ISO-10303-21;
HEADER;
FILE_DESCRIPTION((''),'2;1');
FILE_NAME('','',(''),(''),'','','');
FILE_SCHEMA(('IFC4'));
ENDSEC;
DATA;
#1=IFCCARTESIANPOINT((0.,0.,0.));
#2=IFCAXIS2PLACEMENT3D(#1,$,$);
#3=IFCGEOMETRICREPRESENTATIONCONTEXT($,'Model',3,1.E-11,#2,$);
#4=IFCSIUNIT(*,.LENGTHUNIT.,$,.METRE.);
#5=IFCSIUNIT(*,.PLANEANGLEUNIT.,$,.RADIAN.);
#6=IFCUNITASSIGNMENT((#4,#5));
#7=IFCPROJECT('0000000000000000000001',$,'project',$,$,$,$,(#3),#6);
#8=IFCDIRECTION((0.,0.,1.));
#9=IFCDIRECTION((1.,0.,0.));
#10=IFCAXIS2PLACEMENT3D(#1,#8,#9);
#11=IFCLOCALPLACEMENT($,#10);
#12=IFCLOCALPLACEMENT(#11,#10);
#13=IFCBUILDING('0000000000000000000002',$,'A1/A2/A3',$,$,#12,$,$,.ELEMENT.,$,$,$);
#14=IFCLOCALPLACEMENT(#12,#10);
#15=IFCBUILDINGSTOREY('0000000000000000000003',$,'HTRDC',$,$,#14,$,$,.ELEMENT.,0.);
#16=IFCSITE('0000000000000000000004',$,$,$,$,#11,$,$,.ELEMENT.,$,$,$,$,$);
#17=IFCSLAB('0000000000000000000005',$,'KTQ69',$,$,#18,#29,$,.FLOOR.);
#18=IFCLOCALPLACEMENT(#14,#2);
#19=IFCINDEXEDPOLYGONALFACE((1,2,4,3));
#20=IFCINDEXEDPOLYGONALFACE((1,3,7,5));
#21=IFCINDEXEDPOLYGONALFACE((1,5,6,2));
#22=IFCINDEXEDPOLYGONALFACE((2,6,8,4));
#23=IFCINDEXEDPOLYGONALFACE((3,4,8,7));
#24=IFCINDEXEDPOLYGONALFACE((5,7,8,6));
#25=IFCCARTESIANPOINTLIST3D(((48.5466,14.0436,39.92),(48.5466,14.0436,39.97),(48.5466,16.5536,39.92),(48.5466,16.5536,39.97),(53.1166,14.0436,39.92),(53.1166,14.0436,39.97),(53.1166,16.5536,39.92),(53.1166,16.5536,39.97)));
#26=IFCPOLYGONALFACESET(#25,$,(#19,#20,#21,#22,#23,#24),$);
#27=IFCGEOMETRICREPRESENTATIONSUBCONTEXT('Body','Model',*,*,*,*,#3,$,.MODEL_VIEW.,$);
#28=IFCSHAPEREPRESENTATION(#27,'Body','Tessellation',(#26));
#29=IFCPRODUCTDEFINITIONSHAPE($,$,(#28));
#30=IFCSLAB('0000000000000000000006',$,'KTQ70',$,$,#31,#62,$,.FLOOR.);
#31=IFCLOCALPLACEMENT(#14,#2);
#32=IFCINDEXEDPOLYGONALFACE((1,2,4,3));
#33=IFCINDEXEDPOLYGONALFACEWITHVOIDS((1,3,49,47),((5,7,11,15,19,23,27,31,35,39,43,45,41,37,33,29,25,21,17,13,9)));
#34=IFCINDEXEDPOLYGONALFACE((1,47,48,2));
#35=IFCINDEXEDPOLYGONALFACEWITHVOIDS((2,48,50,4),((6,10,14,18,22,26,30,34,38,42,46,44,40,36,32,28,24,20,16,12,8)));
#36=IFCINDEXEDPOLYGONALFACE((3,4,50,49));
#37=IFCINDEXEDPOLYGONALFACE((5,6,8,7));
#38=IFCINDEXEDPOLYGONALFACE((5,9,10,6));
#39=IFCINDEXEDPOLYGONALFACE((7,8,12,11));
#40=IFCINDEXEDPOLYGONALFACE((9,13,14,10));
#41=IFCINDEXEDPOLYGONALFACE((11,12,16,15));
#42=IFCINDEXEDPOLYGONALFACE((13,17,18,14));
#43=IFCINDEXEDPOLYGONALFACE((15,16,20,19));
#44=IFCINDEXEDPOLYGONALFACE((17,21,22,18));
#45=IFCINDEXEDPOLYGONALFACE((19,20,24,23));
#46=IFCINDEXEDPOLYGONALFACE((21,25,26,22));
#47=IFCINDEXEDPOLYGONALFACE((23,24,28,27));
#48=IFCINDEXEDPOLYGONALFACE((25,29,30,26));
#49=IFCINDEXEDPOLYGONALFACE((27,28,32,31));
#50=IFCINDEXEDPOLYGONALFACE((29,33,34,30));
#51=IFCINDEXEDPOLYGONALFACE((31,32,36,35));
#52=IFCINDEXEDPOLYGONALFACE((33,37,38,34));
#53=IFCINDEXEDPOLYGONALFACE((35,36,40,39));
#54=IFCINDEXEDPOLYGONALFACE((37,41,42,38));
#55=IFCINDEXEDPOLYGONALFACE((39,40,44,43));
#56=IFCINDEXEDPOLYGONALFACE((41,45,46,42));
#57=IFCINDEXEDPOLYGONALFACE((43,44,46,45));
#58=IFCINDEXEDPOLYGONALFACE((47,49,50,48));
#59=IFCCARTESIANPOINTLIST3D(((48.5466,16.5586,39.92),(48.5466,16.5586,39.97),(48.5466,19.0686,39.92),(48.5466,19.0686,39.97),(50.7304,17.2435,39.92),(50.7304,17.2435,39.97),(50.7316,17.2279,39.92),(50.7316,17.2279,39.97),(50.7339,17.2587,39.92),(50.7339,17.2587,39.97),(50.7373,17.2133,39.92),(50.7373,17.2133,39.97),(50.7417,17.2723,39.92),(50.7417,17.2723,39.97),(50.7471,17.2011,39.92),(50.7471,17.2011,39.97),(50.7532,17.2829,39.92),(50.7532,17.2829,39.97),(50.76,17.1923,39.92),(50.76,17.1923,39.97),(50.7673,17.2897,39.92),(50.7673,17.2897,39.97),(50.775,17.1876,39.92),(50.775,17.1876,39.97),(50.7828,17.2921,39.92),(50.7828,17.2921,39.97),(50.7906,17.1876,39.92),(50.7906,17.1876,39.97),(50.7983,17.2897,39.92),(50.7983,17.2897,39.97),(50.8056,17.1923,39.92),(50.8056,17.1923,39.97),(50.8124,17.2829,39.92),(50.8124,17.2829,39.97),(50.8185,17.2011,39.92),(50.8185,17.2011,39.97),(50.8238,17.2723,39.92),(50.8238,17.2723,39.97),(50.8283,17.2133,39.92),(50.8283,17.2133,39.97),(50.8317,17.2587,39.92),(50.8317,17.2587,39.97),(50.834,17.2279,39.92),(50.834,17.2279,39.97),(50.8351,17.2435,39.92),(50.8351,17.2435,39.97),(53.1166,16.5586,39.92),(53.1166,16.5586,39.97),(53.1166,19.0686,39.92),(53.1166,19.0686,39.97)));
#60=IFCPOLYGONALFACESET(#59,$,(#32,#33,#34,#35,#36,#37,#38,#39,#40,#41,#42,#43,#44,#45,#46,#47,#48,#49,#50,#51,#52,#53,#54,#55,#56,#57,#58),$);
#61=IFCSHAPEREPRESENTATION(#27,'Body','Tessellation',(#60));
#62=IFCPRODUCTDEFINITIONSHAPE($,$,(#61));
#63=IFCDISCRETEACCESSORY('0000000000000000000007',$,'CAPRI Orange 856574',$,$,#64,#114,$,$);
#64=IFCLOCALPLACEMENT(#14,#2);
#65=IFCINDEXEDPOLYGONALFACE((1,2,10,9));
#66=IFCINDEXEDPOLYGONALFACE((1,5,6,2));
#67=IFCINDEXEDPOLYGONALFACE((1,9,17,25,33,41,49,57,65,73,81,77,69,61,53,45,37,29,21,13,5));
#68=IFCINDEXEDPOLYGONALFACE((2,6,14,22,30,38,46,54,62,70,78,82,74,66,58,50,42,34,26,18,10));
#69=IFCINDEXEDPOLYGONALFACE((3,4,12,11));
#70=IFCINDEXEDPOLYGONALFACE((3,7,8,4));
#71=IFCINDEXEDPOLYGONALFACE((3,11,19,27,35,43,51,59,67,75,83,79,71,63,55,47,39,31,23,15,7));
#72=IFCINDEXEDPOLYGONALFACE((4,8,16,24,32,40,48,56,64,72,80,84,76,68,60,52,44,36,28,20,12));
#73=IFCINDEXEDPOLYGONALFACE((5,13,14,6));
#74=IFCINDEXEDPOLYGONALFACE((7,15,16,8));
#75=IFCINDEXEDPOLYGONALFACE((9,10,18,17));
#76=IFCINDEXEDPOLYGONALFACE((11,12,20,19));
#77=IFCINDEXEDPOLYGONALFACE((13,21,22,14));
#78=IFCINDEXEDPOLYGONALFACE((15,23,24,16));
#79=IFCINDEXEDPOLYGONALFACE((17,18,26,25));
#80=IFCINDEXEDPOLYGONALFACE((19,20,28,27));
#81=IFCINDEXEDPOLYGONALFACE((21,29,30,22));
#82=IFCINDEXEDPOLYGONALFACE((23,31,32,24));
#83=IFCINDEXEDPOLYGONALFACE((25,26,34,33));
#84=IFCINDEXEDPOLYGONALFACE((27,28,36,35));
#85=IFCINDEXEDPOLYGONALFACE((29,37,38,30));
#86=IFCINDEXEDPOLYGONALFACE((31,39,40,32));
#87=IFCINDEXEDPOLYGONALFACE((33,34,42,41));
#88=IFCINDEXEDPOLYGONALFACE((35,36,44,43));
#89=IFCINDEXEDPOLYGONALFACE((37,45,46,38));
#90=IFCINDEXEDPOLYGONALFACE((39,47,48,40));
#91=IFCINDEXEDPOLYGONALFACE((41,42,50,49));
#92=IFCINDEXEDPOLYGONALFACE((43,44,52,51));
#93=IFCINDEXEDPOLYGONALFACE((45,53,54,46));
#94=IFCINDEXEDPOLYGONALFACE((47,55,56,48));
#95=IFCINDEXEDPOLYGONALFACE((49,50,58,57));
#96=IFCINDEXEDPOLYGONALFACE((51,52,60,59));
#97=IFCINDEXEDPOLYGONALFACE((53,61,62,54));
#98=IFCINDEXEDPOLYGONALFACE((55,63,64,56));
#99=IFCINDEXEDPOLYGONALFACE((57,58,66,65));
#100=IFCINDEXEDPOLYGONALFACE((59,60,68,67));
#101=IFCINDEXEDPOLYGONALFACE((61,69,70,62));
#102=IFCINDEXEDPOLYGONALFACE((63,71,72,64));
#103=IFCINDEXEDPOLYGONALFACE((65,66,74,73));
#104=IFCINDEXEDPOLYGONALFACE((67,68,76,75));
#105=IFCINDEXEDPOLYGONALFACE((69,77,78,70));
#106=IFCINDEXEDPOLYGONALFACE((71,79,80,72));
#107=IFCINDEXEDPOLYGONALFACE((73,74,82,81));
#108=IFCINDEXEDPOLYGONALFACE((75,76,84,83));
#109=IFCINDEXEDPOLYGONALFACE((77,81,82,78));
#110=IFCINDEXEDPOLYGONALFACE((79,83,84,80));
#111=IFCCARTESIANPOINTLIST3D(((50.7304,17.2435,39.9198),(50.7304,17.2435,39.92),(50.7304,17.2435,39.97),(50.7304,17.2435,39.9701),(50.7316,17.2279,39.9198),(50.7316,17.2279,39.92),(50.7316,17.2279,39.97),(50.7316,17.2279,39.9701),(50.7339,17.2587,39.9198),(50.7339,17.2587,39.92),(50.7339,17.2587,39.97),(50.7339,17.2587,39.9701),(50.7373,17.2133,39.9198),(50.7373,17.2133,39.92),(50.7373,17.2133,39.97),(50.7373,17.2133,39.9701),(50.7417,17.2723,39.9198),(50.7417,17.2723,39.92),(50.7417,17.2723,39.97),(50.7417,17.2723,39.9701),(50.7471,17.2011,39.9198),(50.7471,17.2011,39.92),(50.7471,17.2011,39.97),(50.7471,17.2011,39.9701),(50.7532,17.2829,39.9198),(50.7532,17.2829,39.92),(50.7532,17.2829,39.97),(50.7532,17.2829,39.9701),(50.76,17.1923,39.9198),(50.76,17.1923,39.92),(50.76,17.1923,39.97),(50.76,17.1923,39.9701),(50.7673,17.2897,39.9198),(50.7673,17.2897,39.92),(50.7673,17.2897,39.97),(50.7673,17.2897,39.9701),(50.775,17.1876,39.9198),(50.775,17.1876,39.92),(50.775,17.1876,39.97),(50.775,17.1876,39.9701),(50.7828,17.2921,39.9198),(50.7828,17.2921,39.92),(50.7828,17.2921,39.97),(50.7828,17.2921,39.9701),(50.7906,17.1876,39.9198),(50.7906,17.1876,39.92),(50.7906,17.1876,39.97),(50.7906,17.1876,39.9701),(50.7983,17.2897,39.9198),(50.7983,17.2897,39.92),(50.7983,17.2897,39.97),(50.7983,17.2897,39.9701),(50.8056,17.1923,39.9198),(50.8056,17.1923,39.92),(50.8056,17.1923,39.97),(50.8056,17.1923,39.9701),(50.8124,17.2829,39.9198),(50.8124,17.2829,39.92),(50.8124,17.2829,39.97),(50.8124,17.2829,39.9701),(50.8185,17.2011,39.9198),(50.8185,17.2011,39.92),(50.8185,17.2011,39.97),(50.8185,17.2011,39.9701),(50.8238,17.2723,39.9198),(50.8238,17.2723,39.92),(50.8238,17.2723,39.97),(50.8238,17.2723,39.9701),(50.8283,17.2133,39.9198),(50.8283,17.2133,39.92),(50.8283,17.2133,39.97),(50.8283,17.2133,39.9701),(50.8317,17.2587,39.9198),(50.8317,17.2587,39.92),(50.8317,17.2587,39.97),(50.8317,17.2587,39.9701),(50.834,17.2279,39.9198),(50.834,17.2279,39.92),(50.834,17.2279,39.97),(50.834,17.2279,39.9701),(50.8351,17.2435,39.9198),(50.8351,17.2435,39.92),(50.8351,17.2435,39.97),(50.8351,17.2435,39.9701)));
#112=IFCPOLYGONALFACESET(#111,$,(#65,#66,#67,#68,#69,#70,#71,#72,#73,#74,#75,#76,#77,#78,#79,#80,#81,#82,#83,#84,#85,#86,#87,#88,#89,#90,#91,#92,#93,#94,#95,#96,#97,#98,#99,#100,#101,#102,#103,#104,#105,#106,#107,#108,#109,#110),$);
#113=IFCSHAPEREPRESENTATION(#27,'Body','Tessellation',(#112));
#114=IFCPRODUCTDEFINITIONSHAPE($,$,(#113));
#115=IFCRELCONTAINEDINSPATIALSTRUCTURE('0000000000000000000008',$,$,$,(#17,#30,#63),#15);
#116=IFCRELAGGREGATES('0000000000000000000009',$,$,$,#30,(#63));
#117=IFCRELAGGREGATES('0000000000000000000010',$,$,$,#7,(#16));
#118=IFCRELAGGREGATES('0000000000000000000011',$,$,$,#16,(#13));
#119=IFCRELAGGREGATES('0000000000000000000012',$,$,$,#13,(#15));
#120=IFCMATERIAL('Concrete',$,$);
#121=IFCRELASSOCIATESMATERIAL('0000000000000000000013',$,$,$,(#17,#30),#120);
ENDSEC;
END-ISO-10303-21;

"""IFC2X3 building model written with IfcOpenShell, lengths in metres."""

from ifc_helpers import new_model, si_unit, frame, frame_2d, origin, origin_with_axes, origin_2d_with_axis, place, context, subcontext, project, spatial, polyline, circle, outline, extrude, material, element, aggregate, save


model = new_model("IFC2X3")

# Units and contexts
model_context = context("Model", 3, precision=1e-11, world=origin())
body_context = subcontext(model_context, "Body", "Model", "MODEL_VIEW")
ifc_project = project(units=[si_unit("LENGTHUNIT", "METRE"), si_unit("PLANEANGLEUNIT", "RADIAN")], contexts=[model_context])

# Site, building, storey
site_placement = place(None, origin_with_axes())
site = spatial("IfcSite", under=ifc_project, at=site_placement, CompositionType="ELEMENT")
building_placement = place(site_placement, origin_with_axes())
building = spatial("IfcBuilding", under=site, at=building_placement, Name="A1/A2/A3", CompositionType="ELEMENT")
storey_placement = place(building_placement, origin_with_axes())
storey = spatial("IfcBuildingStorey", under=building, at=storey_placement, Name="HTRDC", CompositionType="ELEMENT", Elevation=0.0)

# Slab
ifc_material = material(Name="Concrete")
slab_1_placement = place(storey_placement, frame((48.5466, 14.0436, 39.92), z_axis=(0.0, 0.0, 1.0), x_axis=(1.0, 0.0, 0.0)))
element("IfcSlab", 1, at=slab_1_placement, inside=storey, material=ifc_material, Name="KTQ69", PredefinedType="FLOOR", context=body_context, shape_type="SweptSolid", body=[
    extrude(outline(polyline([(0.0, 0.0), (0.0, -4.57), (2.51, -4.57), (2.51, 0.0), (0.0, 0.0)])), frame((0.0, 0.0, 0.0), z_axis=(0.0, 0.0, 1.0), x_axis=(0.0, 1.0, 0.0)), (0.0, 0.0, 1.0), 0.05),
])

# Slab, opening
slab_2_placement = place(storey_placement, frame((48.5466, 16.5586, 39.92), z_axis=(0.0, 0.0, 1.0), x_axis=(1.0, 0.0, 0.0)))
slab_2 = element("IfcSlab", 2, at=slab_2_placement, inside=storey, material=ifc_material, Name="KTQ70", PredefinedType="FLOOR", context=body_context, shape_type="SweptSolid", body=[
    extrude(outline(polyline([(0.0, 0.0), (0.0, -4.57), (2.51, -4.57), (2.51, 0.0), (0.0, 0.0)])), frame((0.0, 0.0, 0.0), z_axis=(0.0, 0.0, 1.0), x_axis=(0.0, 1.0, 0.0)), (0.0, 0.0, 1.0), 0.05),
])
opening_1_placement = place(slab_2_placement, frame((2.2362, 0.6809, 0.0), z_axis=(0.0, 0.0, 1.0), x_axis=(1.0, 0.0, 0.0)))
element("IfcOpeningElement", 3, at=opening_1_placement, cuts=slab_2, ObjectType="Opening", context=body_context, shape_type="SweptSolid", body=[
    extrude(circle(Radius=0.0525, at=origin_2d_with_axis()), frame((0.0, 0.0, 0.0), z_axis=(0.0, 0.0, 1.0), x_axis=(0.0, 1.0, 0.0)), (0.0, 0.0, 1.0), 0.05),
])

# Discrete accessory
discrete_accessory_1_placement = place(storey_placement, frame((48.5466, 16.5586, 39.9198), z_axis=(0.0, 0.0, 1.0), x_axis=(1.0, 0.0, 0.0)))
discrete_accessory_1 = element("IfcDiscreteAccessory", 4, at=discrete_accessory_1_placement, inside=storey, Name="CAPRI Orange 856574", context=body_context, shape_type="SweptSolid", body=[
    extrude(circle(Radius=0.0525, at=frame_2d((0.6809, -2.2362), x_axis=(1.0, 0.0))), frame((0.0, 0.0, 0.0), z_axis=(0.0, 0.0, 1.0), x_axis=(0.0, 1.0, 0.0)), (0.0, 0.0, 1.0), 0.0503),
])
aggregate(slab_2, [discrete_accessory_1])

save(model, "model.ifc")
